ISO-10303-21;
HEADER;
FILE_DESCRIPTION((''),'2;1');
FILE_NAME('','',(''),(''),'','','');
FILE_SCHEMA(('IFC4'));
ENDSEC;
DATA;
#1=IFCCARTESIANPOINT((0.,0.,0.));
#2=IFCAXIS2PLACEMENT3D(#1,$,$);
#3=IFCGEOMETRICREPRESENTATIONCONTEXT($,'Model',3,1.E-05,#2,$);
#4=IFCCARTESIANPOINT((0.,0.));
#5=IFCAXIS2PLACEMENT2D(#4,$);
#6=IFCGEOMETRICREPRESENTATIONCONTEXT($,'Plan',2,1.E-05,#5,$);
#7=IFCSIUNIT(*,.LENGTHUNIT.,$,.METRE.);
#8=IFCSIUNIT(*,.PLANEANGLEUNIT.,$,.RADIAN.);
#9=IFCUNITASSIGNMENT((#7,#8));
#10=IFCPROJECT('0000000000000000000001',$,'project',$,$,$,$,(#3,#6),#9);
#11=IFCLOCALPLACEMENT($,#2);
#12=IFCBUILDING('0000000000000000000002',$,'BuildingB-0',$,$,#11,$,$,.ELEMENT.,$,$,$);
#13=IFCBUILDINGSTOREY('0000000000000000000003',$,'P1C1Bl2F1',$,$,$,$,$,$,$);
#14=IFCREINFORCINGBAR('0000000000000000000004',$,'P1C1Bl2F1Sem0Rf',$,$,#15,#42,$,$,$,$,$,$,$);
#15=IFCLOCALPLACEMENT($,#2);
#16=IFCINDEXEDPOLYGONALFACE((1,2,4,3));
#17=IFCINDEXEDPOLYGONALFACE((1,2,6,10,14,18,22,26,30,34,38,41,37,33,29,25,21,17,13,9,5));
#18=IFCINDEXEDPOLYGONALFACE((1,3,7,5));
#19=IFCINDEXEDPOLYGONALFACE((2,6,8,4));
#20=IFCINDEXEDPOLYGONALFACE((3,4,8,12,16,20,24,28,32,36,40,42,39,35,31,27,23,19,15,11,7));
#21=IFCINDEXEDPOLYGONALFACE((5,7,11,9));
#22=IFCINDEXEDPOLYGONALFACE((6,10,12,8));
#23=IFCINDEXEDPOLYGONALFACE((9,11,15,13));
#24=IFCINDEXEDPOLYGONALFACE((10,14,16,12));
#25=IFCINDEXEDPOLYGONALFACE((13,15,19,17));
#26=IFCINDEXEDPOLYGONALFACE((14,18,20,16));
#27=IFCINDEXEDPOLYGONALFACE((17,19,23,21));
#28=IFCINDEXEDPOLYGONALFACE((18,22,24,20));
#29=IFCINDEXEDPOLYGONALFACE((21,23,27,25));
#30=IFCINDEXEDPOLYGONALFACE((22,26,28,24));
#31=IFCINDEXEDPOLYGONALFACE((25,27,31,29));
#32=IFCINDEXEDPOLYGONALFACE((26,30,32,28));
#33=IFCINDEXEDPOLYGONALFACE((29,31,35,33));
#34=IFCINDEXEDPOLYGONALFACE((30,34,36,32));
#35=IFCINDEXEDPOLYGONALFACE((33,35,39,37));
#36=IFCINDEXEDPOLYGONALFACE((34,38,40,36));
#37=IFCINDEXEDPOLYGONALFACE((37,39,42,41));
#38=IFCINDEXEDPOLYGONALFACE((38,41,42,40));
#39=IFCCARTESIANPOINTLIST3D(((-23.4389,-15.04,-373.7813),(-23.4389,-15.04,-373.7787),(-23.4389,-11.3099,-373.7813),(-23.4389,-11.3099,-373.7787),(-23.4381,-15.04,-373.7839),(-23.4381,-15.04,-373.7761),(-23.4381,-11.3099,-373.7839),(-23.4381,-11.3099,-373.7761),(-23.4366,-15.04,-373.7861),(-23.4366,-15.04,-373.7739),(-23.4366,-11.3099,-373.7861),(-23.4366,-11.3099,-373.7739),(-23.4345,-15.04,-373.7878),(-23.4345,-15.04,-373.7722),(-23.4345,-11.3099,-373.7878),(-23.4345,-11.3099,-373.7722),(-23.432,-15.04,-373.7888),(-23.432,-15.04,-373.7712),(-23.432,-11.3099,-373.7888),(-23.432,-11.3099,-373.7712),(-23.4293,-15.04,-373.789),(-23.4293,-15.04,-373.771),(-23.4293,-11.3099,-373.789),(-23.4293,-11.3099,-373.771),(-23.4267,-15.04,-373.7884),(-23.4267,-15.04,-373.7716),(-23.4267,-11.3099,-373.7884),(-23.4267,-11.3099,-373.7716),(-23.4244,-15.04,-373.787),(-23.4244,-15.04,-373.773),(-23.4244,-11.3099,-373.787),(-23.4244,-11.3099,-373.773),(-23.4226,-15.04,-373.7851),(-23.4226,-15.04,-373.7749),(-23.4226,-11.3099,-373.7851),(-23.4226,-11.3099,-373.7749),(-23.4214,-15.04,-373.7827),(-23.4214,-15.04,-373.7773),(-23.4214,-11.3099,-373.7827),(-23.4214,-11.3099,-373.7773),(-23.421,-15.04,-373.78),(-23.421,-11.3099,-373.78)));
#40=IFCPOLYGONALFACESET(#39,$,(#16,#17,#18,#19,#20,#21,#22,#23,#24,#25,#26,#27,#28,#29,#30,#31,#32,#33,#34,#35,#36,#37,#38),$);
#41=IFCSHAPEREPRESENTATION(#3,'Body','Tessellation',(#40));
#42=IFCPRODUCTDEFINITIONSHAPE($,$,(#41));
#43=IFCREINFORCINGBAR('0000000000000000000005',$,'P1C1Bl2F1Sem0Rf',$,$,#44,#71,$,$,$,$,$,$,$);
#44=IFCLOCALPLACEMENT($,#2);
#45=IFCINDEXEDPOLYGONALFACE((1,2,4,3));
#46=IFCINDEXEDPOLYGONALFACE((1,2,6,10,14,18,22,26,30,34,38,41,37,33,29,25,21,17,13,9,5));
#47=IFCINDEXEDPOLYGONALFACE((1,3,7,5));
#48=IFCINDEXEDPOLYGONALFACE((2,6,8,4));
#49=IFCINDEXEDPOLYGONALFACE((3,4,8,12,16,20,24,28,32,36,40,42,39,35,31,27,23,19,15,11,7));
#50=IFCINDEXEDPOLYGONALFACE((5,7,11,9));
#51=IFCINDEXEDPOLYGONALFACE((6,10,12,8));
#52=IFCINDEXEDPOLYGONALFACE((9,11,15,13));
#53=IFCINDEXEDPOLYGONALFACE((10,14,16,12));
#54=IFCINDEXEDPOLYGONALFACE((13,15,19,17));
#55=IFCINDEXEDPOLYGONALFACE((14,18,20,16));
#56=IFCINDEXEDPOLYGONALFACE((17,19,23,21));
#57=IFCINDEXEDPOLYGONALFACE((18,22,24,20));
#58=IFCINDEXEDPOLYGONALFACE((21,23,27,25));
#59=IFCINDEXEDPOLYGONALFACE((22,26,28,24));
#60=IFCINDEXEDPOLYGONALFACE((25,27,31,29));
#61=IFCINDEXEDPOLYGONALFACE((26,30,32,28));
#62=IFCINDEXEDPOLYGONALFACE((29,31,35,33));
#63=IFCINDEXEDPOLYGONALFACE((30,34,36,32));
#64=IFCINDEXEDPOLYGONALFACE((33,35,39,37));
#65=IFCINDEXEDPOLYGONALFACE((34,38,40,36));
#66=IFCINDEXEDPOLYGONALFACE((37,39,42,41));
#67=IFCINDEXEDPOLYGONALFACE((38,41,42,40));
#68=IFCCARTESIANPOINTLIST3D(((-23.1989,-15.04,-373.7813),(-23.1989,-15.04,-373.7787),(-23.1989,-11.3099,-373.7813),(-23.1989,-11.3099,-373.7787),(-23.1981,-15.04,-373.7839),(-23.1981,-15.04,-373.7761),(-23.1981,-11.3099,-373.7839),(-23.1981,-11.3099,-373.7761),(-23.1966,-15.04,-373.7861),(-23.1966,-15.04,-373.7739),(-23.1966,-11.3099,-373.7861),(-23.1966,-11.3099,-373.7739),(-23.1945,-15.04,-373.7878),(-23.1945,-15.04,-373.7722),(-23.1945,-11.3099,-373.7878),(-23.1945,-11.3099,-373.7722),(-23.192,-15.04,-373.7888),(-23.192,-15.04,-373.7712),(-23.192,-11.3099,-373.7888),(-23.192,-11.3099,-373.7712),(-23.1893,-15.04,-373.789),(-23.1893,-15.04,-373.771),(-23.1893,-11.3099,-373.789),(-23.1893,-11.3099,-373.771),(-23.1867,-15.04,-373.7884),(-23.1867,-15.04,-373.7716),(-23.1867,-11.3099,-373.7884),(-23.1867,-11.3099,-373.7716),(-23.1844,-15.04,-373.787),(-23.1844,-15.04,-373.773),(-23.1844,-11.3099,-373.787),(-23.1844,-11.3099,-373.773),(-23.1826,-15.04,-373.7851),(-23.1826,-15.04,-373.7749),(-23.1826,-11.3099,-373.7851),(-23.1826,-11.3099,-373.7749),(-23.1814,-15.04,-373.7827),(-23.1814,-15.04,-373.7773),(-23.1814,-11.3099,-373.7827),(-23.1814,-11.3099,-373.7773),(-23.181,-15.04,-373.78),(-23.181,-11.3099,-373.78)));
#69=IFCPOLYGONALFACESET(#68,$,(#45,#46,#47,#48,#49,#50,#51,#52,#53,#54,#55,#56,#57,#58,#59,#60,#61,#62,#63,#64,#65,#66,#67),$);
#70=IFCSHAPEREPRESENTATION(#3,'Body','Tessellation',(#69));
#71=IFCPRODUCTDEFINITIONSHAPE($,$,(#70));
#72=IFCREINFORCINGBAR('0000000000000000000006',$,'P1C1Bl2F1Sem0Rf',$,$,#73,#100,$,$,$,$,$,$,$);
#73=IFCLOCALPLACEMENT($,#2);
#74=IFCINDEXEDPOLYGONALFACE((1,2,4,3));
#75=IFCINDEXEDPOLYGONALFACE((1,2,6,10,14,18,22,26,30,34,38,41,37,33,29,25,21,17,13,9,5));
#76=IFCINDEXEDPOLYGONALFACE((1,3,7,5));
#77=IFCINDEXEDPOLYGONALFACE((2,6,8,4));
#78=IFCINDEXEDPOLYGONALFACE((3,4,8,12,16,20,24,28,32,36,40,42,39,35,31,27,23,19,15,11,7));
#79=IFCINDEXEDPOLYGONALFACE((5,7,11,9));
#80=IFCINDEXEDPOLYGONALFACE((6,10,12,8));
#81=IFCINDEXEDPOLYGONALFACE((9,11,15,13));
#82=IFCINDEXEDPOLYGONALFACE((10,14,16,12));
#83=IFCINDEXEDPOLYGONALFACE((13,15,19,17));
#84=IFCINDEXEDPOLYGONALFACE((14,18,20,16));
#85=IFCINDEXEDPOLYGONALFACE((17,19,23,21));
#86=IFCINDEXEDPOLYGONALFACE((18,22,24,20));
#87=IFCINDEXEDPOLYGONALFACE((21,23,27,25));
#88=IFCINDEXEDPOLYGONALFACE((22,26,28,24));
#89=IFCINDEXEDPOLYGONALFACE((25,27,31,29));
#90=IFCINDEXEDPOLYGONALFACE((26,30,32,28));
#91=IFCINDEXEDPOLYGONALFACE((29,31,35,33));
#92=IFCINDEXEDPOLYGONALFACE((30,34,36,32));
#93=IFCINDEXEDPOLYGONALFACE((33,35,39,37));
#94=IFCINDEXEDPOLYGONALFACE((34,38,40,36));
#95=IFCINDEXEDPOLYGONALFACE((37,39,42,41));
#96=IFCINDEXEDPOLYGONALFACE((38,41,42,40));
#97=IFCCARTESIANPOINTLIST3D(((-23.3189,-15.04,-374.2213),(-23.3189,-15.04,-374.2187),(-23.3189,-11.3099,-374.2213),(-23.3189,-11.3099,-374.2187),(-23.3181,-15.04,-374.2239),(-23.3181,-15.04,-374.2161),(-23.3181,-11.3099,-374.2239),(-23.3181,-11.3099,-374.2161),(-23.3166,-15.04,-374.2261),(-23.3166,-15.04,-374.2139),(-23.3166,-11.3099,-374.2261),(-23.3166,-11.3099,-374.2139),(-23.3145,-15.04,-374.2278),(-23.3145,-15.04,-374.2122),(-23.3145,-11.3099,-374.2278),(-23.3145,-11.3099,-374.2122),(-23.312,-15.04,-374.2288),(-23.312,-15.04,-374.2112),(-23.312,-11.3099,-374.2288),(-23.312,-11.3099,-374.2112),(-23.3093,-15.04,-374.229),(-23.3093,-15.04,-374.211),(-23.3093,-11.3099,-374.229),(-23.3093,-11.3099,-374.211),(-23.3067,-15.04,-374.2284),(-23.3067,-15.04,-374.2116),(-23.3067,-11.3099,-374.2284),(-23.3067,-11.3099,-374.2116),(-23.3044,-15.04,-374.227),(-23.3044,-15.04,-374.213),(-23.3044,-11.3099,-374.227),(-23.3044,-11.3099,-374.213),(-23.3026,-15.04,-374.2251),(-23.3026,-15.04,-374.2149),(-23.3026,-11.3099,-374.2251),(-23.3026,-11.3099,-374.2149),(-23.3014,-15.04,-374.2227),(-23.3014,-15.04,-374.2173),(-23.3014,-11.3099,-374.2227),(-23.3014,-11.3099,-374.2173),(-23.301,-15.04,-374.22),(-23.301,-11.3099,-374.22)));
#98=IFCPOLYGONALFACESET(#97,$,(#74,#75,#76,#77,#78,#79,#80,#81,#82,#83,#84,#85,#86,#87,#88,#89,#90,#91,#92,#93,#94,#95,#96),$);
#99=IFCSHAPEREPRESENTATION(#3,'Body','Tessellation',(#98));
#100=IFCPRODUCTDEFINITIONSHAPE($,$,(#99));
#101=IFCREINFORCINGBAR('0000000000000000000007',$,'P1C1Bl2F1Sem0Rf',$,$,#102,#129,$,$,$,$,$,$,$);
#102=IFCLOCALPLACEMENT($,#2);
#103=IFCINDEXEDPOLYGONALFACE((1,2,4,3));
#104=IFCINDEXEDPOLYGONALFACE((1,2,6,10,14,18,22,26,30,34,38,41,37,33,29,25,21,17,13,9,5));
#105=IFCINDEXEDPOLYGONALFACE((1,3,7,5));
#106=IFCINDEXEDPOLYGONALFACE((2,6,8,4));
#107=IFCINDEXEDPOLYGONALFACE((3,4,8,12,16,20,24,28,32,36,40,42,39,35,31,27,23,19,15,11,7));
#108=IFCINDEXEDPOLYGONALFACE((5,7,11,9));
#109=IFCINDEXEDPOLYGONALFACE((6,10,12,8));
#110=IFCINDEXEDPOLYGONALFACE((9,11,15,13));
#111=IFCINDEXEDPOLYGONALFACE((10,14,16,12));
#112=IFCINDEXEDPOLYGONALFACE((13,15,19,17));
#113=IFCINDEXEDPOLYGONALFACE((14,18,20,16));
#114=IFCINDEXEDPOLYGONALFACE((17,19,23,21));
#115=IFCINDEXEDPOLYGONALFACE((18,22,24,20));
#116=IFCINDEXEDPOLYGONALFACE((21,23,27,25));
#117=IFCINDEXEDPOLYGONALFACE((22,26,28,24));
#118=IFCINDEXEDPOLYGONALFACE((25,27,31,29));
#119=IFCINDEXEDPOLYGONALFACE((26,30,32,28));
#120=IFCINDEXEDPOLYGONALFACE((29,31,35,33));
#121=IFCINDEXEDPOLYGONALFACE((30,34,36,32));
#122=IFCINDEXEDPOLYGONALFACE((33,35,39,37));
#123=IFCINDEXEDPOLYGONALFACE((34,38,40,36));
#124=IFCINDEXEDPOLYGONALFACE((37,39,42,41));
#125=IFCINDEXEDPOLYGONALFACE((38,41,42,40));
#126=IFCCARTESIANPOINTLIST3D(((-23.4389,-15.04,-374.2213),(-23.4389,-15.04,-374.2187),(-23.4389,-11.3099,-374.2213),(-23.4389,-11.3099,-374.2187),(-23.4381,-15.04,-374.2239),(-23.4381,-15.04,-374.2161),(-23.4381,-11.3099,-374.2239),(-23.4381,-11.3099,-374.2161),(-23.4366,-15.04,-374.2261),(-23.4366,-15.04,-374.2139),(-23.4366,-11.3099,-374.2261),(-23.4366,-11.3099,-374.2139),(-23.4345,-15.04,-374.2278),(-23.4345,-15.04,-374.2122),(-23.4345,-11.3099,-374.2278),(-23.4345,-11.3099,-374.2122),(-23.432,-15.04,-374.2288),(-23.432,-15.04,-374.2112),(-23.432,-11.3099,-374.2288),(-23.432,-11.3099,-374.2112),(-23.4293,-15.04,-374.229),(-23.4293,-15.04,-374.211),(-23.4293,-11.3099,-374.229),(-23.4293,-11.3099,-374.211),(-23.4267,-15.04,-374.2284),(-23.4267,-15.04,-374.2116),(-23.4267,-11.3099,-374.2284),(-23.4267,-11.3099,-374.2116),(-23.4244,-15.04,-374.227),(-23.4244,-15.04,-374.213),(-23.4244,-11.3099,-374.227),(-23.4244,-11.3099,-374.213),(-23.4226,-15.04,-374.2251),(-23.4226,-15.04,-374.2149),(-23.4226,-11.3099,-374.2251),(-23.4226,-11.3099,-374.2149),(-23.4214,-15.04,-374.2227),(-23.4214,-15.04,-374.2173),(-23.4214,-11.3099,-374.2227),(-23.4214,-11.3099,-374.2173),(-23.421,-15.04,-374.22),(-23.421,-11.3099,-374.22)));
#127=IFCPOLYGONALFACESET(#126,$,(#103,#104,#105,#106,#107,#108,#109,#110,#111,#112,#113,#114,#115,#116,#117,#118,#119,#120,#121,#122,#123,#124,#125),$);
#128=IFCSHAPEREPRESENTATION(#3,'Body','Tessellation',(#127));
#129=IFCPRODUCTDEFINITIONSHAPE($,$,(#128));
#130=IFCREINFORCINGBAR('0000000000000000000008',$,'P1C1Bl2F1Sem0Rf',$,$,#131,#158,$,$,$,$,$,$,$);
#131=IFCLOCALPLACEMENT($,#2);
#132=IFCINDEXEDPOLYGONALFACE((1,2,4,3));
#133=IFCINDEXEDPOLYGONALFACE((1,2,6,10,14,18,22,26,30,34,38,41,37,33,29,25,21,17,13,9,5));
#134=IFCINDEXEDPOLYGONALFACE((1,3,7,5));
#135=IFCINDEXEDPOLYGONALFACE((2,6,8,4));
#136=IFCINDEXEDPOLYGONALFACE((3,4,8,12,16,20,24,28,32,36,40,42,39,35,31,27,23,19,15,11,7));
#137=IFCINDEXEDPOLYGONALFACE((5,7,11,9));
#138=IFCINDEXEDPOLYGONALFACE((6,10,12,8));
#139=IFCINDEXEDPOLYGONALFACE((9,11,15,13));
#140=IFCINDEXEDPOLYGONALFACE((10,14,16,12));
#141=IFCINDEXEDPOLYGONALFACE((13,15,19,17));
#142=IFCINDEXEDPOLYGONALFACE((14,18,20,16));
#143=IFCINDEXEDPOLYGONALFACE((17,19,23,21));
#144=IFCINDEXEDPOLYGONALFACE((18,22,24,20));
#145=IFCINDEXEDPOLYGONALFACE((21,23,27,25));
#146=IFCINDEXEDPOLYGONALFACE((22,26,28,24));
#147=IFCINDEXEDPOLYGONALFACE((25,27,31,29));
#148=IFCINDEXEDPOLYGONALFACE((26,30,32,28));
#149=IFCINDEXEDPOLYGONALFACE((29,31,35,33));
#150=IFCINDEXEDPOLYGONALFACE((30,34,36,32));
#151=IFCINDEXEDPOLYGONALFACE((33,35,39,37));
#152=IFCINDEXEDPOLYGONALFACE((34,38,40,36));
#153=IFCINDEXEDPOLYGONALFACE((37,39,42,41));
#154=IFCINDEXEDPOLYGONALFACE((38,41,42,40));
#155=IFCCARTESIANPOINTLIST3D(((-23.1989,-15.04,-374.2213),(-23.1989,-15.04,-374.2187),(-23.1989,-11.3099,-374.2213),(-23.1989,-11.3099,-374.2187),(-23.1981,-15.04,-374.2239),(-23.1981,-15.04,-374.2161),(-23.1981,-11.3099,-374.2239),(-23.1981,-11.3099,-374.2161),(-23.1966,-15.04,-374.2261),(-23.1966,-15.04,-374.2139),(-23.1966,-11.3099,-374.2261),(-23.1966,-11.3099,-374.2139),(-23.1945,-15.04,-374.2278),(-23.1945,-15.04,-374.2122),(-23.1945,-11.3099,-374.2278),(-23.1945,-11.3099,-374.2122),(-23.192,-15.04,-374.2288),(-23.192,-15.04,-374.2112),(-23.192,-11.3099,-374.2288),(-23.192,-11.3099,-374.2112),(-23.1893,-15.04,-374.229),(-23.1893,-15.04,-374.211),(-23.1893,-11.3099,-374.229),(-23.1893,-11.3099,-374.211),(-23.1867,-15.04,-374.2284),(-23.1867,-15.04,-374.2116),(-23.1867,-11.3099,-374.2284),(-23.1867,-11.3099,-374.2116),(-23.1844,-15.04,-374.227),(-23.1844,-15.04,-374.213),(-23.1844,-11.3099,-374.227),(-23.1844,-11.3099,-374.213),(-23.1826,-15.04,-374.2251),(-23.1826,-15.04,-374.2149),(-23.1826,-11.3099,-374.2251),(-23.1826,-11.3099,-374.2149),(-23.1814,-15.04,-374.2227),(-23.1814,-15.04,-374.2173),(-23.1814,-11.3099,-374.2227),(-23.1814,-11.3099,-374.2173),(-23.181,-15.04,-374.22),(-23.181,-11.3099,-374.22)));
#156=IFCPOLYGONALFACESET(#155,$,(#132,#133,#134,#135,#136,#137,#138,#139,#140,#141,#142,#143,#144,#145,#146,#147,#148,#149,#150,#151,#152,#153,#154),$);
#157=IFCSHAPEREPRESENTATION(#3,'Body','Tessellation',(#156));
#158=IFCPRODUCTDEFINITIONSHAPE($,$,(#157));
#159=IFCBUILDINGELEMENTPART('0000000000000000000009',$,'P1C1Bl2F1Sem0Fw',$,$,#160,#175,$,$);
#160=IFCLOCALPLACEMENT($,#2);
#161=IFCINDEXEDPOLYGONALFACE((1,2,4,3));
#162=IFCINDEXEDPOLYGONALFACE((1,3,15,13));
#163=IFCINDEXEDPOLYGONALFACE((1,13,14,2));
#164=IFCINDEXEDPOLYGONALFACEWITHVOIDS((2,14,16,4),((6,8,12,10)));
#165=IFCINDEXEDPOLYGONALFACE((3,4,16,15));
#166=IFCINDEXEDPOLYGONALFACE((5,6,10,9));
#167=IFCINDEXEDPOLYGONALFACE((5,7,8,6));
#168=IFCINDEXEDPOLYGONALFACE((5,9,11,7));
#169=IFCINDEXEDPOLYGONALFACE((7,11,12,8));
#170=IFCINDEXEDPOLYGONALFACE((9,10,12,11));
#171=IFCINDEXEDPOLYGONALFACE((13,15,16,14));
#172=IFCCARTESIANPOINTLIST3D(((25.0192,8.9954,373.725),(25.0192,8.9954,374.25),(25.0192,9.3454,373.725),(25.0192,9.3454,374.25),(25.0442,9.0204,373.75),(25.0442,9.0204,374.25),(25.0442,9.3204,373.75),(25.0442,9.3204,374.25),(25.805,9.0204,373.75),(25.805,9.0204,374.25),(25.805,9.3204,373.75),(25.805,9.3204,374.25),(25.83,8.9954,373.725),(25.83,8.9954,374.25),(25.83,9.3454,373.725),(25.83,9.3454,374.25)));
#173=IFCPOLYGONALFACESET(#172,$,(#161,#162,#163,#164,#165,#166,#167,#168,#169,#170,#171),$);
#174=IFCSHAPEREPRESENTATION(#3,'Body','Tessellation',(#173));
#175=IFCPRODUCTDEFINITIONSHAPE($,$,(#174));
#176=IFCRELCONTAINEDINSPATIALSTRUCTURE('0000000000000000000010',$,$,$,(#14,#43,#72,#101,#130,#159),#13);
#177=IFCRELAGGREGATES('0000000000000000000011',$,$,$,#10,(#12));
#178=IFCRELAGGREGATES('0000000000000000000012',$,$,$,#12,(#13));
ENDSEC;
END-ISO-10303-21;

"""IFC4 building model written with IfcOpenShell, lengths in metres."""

from ifc_helpers import new_model, entity, si_unit, origin, origin_2d, place, context, project, spatial, polyline, outline, extrude, element, save


model = new_model("IFC4")

# Units and contexts
model_context = context("Model", 3, precision=1e-05, world=origin())
plan_context = context("Plan", 2, precision=1e-05, world=origin_2d())
ifc_project = project(units=[si_unit("LENGTHUNIT", "METRE"), si_unit("PLANEANGLEUNIT", "RADIAN")], contexts=[model_context, plan_context])

# Building, storey
building_placement = place(None, origin())
building = spatial("IfcBuilding", under=ifc_project, at=building_placement, Name="BuildingB-0", CompositionType="ELEMENT")
storey = spatial("IfcBuildingStorey", under=building, Name="P1C1Bl2F1")

# Reinforcing bars
element("IfcReinforcingBar", 1, inside=storey, Name="P1C1Bl2F1Sem0Rf", context=model_context, shape_type="SweptSolid", body=[
    entity("IfcSurfaceCurveSweptAreaSolid", entity("IfcCircleProfileDef", "AREA", None, None, 0.009), None, entity("IfcPolyline", [entity("IfcCartesianPoint", [23.43, 11.3099, 373.78]), entity("IfcCartesianPoint", [23.43, 15.04, 373.78])]), None, None, entity("IfcPlane", entity("IfcAxis2Placement3D", entity("IfcCartesianPoint", [23.43, 11.3099, 373.78]), entity("IfcDirection", [0.0, 0.0, 1.0]), entity("IfcDirection", [1.0, 0.0, 0.0])))),
])
element("IfcReinforcingBar", 2, inside=storey, Name="P1C1Bl2F1Sem0Rf", context=model_context, shape_type="SweptSolid", body=[
    entity("IfcSurfaceCurveSweptAreaSolid", entity("IfcCircleProfileDef", "AREA", None, None, 0.009), None, entity("IfcPolyline", [entity("IfcCartesianPoint", [23.19, 11.3099, 373.78]), entity("IfcCartesianPoint", [23.19, 15.04, 373.78])]), None, None, entity("IfcPlane", entity("IfcAxis2Placement3D", entity("IfcCartesianPoint", [23.19, 11.3099, 373.78]), entity("IfcDirection", [0.0, 0.0, 1.0]), entity("IfcDirection", [1.0, 0.0, 0.0])))),
])
element("IfcReinforcingBar", 3, inside=storey, Name="P1C1Bl2F1Sem0Rf", context=model_context, shape_type="SweptSolid", body=[
    entity("IfcSurfaceCurveSweptAreaSolid", entity("IfcCircleProfileDef", "AREA", None, None, 0.009), None, entity("IfcPolyline", [entity("IfcCartesianPoint", [23.31, 11.3099, 374.22]), entity("IfcCartesianPoint", [23.31, 15.04, 374.22])]), None, None, entity("IfcPlane", entity("IfcAxis2Placement3D", entity("IfcCartesianPoint", [23.31, 11.3099, 374.22]), entity("IfcDirection", [0.0, 0.0, 1.0]), entity("IfcDirection", [1.0, 0.0, 0.0])))),
])
element("IfcReinforcingBar", 4, inside=storey, Name="P1C1Bl2F1Sem0Rf", context=model_context, shape_type="SweptSolid", body=[
    entity("IfcSurfaceCurveSweptAreaSolid", entity("IfcCircleProfileDef", "AREA", None, None, 0.009), None, entity("IfcPolyline", [entity("IfcCartesianPoint", [23.43, 11.3099, 374.22]), entity("IfcCartesianPoint", [23.43, 15.04, 374.22])]), None, None, entity("IfcPlane", entity("IfcAxis2Placement3D", entity("IfcCartesianPoint", [23.43, 11.3099, 374.22]), entity("IfcDirection", [0.0, 0.0, 1.0]), entity("IfcDirection", [1.0, 0.0, 0.0])))),
])
element("IfcReinforcingBar", 5, inside=storey, Name="P1C1Bl2F1Sem0Rf", context=model_context, shape_type="SweptSolid", body=[
    entity("IfcSurfaceCurveSweptAreaSolid", entity("IfcCircleProfileDef", "AREA", None, None, 0.009), None, entity("IfcPolyline", [entity("IfcCartesianPoint", [23.19, 11.3099, 374.22]), entity("IfcCartesianPoint", [23.19, 15.04, 374.22])]), None, None, entity("IfcPlane", entity("IfcAxis2Placement3D", entity("IfcCartesianPoint", [23.19, 11.3099, 374.22]), entity("IfcDirection", [0.0, 0.0, 1.0]), entity("IfcDirection", [1.0, 0.0, 0.0])))),
])

# Building element part, opening
building_element_part_1 = element("IfcBuildingElementPart", 6, inside=storey, Name="P1C1Bl2F1Sem0Fw", context=model_context, shape_type="SweptSolid", body=[
    extrude(outline(polyline([(25.0192, 8.9954, 373.725), (25.83, 8.9954, 373.725), (25.83, 9.3454, 373.725), (25.0192, 9.3454, 373.725), (25.0192, 8.9954, 373.725)])), None, (0.0, 0.0, 1.0), 0.525),
])
element("IfcOpeningElement", 7, inside=storey, cuts=building_element_part_1, context=model_context, shape_type="SweptSolid", body=[
    extrude(outline(polyline([(25.0442, 9.0204, 373.75), (25.805, 9.0204, 373.75), (25.805, 9.3204, 373.75), (25.0442, 9.3204, 373.75), (25.0442, 9.0204, 373.75)])), None, (0.0, 0.0, 1.0), 0.5),
])

save(model, "model.ifc")
